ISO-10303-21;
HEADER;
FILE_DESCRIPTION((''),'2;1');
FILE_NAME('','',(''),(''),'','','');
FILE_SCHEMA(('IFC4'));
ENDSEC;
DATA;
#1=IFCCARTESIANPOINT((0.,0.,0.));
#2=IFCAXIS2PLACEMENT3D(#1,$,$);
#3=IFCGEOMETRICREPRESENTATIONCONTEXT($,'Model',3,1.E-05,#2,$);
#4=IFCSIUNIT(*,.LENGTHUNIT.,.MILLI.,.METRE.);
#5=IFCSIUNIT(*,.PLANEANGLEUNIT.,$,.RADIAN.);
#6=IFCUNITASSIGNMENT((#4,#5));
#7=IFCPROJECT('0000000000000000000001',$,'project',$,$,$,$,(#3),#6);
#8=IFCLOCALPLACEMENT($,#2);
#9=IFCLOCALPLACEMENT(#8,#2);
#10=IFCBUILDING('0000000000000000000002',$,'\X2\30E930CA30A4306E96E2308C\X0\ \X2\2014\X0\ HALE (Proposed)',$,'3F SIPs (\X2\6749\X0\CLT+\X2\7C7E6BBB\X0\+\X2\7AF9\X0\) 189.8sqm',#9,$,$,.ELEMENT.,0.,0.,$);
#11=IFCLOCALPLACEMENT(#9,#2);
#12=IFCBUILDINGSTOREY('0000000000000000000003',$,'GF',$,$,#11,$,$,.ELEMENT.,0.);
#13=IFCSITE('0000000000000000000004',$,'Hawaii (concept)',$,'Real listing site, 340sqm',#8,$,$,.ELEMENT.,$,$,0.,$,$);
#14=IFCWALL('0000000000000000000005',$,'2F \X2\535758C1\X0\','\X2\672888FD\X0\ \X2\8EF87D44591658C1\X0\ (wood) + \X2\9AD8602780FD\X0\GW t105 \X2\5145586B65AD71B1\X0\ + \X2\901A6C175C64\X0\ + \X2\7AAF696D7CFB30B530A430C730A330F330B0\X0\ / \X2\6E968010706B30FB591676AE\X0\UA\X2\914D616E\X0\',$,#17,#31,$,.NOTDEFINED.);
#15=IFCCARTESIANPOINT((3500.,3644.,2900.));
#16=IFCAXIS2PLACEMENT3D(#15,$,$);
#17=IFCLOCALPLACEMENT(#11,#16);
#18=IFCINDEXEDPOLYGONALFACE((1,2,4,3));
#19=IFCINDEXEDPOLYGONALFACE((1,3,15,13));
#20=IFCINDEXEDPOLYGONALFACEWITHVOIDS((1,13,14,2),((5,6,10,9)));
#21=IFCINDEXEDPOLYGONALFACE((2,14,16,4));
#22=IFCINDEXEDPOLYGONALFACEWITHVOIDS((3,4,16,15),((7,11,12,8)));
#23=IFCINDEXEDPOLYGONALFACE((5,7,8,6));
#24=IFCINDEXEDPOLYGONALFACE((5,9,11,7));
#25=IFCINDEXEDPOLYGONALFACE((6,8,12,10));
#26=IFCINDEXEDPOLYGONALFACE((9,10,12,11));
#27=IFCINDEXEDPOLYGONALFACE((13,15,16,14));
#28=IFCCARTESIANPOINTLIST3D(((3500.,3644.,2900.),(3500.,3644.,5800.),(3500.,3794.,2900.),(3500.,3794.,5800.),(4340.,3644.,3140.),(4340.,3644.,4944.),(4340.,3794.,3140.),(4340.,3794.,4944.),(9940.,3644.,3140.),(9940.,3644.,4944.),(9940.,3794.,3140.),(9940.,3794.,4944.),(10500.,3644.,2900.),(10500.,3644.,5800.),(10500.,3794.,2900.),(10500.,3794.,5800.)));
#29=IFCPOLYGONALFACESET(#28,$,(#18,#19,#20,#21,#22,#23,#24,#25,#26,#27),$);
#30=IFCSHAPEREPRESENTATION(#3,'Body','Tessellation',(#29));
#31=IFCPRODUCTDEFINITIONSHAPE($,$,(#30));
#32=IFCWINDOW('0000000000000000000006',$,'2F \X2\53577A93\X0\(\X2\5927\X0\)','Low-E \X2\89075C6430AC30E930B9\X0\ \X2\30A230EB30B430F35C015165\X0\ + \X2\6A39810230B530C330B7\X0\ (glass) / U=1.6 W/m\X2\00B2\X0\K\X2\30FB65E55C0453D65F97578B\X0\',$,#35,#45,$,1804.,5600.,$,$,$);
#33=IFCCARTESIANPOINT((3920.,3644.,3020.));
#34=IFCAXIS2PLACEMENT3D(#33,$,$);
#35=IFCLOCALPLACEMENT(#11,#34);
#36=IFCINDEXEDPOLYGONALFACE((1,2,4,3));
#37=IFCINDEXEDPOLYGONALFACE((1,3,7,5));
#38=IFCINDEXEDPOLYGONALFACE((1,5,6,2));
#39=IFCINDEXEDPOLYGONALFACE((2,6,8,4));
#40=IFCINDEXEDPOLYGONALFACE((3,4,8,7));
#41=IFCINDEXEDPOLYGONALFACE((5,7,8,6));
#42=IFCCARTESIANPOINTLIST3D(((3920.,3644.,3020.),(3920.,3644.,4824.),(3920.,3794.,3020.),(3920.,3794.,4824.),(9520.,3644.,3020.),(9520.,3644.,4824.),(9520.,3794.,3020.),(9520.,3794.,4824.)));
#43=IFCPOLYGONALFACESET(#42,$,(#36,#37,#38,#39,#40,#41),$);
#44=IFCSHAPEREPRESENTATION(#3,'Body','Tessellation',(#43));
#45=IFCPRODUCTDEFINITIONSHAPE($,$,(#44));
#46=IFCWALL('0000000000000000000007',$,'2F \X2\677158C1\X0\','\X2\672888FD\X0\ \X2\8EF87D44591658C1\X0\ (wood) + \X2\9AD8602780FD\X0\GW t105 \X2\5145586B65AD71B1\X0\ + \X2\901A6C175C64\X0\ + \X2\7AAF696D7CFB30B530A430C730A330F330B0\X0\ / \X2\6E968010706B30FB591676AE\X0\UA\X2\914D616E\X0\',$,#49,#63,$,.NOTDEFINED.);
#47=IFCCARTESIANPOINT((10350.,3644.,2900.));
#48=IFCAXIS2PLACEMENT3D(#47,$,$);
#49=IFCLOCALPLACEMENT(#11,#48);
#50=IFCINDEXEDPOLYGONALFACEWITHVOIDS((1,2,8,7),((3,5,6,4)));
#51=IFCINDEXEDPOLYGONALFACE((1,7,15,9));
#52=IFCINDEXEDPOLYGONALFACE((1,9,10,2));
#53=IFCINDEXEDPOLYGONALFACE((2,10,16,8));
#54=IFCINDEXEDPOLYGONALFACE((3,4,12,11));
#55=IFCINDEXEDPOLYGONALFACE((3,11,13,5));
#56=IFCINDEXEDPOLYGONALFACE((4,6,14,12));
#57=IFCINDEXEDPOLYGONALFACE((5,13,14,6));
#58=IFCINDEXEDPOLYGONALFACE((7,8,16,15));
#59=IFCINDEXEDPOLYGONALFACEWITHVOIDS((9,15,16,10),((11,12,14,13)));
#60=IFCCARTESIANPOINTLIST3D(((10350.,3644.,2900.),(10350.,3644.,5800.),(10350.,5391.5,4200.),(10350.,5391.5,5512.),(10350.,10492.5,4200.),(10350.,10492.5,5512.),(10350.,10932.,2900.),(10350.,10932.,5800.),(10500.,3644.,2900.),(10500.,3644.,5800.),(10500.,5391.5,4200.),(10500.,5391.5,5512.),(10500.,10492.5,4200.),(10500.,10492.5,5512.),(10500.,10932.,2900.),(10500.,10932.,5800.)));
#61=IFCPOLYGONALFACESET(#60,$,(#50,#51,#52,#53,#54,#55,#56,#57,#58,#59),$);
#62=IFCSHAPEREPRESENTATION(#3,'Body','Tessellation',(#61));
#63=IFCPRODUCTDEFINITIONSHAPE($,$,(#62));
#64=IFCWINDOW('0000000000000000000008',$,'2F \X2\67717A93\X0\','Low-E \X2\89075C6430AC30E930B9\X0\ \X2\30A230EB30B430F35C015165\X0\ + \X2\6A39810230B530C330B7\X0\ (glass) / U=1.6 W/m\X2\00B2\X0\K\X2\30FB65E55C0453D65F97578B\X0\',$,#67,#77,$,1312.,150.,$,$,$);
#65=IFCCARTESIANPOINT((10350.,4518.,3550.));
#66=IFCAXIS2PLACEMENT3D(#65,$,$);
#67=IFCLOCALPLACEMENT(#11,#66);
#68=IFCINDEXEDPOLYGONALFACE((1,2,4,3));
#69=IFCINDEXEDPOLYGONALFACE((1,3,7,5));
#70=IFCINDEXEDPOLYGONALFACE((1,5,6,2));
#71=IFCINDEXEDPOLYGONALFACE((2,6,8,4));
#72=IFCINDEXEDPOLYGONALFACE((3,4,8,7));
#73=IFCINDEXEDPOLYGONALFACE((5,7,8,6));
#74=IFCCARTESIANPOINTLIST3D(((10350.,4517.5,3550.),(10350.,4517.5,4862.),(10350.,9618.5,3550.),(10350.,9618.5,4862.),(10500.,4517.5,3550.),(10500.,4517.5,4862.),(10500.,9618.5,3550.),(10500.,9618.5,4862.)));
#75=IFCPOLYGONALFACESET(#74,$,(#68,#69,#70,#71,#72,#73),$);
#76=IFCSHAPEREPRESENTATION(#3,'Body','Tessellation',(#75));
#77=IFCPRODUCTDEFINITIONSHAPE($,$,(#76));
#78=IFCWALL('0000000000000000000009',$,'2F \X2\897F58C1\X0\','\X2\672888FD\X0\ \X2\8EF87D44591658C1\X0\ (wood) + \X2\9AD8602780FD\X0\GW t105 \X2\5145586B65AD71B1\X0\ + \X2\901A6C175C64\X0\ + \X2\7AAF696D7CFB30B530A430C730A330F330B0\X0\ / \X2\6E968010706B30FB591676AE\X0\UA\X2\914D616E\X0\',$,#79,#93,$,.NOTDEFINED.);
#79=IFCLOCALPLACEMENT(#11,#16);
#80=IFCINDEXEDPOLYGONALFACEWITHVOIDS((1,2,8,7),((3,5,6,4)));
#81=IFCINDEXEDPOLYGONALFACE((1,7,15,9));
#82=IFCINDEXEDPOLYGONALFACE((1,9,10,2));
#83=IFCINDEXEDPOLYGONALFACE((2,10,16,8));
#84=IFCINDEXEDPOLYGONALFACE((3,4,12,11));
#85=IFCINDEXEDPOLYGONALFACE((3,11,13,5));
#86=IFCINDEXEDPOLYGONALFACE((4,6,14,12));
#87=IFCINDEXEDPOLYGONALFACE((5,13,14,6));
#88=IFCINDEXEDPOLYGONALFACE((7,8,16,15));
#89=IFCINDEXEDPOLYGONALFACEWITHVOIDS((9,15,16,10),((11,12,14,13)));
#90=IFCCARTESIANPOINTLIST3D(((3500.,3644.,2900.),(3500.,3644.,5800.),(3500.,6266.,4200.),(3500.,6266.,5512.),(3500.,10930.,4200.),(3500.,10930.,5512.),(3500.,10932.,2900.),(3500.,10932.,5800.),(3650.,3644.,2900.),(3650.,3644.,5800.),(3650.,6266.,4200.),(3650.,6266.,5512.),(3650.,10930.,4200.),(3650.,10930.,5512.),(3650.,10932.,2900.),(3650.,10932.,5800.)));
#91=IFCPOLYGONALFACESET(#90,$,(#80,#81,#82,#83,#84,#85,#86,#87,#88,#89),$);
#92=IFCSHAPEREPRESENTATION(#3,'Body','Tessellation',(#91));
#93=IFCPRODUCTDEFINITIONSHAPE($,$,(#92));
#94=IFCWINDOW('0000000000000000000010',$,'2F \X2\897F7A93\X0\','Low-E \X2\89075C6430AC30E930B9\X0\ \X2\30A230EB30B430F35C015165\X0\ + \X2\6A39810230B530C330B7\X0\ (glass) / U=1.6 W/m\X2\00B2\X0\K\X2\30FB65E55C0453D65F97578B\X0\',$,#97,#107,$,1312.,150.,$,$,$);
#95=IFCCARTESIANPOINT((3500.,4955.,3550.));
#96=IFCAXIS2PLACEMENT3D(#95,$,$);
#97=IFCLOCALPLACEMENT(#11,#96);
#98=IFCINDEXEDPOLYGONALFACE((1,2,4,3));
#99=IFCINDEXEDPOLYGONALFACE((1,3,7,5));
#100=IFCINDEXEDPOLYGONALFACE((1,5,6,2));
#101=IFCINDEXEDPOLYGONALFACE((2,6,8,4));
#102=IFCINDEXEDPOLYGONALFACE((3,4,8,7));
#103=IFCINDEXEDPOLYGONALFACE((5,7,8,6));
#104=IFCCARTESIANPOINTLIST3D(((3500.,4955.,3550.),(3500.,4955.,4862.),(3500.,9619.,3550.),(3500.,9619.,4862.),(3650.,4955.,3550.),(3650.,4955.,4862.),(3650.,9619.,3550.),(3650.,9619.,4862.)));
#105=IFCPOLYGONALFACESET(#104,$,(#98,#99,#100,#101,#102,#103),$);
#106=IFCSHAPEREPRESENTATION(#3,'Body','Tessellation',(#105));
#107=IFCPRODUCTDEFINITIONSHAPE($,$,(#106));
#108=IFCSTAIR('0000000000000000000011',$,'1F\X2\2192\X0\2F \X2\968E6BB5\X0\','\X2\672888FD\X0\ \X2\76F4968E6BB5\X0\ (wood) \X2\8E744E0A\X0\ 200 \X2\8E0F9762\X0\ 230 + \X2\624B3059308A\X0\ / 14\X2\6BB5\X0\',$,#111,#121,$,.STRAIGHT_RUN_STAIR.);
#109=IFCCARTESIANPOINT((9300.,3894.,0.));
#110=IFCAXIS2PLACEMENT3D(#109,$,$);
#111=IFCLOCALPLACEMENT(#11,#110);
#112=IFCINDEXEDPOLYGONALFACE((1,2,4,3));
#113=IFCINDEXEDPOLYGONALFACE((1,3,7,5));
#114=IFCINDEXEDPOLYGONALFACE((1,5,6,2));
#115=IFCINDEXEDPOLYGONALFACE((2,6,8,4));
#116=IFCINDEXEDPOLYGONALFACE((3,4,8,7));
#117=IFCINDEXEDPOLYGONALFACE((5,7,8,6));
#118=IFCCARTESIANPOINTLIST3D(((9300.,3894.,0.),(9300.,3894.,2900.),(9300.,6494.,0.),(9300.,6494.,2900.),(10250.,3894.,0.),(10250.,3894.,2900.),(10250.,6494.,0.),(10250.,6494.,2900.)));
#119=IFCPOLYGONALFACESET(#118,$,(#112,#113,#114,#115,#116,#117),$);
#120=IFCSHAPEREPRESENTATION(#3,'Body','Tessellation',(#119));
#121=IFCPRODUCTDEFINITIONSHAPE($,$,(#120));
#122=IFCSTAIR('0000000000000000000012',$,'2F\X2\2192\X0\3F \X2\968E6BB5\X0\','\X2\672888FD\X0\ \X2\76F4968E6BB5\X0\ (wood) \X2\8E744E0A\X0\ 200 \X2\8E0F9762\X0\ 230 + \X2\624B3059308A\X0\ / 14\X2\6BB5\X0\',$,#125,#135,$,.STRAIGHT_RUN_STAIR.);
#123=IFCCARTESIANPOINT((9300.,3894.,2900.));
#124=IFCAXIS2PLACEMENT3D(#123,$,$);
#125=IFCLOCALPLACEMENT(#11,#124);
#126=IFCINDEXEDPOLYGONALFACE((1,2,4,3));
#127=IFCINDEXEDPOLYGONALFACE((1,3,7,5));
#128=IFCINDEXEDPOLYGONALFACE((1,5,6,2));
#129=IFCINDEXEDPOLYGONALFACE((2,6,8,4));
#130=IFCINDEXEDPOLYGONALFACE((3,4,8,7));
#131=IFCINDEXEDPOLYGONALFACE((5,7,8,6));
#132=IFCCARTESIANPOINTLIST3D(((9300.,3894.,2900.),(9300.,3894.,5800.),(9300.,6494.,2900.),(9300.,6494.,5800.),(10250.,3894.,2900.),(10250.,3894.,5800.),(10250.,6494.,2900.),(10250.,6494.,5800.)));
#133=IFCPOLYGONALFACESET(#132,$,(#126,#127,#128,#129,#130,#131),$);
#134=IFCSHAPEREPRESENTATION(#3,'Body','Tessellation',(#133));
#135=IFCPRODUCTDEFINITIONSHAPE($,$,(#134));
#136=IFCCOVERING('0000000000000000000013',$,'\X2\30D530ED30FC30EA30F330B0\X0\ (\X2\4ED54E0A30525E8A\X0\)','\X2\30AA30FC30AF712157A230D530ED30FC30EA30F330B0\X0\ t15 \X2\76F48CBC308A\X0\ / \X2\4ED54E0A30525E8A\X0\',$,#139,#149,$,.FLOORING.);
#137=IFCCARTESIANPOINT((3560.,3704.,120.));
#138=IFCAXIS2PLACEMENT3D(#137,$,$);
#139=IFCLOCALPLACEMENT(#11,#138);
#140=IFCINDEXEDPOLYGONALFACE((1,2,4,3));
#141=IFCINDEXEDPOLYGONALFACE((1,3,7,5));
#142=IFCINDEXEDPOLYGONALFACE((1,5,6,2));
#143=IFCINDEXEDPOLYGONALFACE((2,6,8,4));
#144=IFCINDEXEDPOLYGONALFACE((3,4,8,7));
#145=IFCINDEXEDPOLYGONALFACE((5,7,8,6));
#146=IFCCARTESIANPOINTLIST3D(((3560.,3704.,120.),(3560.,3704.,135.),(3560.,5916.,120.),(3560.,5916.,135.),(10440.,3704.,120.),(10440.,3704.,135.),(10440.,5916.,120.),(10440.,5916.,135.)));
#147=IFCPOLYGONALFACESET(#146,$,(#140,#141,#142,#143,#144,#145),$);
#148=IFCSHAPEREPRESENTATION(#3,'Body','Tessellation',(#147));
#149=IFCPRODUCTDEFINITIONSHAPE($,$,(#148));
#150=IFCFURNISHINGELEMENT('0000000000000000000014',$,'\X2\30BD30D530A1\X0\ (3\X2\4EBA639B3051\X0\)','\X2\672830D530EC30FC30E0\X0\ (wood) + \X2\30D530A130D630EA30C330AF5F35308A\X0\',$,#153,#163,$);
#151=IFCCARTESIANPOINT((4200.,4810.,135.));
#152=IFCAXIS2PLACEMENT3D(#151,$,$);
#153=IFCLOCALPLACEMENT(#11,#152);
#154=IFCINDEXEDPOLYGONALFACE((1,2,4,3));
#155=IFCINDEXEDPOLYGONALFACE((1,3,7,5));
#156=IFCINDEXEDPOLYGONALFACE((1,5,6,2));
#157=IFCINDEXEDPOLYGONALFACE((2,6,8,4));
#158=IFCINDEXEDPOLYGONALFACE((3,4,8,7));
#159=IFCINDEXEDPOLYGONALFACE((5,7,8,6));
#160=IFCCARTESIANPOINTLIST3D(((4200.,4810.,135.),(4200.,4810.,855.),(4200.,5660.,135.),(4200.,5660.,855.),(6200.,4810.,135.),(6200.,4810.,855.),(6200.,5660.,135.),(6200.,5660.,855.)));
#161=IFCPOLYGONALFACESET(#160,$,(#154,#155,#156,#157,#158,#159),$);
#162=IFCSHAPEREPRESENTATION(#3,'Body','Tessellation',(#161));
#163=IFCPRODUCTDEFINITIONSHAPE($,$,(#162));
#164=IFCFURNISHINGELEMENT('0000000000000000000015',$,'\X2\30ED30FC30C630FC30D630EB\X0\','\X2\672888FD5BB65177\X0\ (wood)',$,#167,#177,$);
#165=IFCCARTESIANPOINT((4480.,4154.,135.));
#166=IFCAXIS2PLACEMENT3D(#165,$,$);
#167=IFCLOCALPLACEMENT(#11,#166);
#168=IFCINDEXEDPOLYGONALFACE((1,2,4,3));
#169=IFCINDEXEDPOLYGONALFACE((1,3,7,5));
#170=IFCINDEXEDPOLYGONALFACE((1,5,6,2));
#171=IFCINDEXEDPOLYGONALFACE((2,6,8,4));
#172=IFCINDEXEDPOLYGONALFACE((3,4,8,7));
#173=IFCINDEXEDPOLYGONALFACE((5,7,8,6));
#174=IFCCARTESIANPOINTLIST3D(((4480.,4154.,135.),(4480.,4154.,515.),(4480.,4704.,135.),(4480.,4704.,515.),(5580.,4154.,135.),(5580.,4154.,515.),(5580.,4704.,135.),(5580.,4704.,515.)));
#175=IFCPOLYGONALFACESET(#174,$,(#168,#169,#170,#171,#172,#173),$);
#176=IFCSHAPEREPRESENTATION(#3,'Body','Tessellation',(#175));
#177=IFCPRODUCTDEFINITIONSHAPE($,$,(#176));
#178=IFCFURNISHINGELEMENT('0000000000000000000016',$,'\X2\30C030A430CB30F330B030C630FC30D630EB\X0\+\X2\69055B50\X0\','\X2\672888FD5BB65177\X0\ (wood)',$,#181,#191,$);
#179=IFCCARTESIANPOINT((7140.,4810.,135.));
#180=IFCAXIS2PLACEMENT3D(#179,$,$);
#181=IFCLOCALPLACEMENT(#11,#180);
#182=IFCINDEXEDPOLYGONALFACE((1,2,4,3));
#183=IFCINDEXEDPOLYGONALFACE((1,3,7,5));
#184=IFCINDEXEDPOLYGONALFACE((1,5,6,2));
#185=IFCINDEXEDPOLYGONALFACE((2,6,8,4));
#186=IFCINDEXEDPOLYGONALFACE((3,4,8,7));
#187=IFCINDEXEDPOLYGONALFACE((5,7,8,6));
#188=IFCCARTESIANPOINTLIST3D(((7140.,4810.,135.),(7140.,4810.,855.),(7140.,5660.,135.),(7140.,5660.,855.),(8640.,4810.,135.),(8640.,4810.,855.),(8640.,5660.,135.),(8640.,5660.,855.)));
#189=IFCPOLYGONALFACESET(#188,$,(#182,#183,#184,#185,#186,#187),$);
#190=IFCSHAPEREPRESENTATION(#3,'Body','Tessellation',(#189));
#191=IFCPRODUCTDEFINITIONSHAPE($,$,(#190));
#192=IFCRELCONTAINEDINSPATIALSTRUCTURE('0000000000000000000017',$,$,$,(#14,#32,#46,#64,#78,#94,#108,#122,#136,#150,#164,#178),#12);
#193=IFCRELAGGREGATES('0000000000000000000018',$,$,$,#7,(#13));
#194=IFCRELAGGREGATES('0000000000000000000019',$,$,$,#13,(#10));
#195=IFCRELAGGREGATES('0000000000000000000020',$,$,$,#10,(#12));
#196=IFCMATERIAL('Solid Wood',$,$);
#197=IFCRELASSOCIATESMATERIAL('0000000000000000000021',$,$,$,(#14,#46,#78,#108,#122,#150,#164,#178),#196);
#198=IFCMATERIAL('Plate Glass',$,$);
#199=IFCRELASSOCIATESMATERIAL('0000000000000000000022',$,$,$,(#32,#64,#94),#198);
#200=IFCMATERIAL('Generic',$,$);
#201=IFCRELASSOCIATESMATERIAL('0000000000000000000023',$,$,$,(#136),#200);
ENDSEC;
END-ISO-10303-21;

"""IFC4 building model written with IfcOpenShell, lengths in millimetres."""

from ifc_helpers import new_model, si_unit, frame, frame_2d, origin, place, context, project, spatial, rectangle, extrude, material, element, fill, save


model = new_model("IFC4")

# Units and contexts
model_context = context("Model", 3, precision=1e-05, world=origin())
ifc_project = project(units=[si_unit("LENGTHUNIT", "METRE", prefix="MILLI"), si_unit("PLANEANGLEUNIT", "RADIAN")], contexts=[model_context])

# Site, building, storey
site_placement = place(None, origin())
site = spatial("IfcSite", under=ifc_project, at=site_placement, Name="Hawaii (concept)", ObjectType="Real listing site, 340sqm", CompositionType="ELEMENT", RefElevation=0.0)
building_placement = place(site_placement, origin())
building = spatial("IfcBuilding", under=site, at=building_placement, Name="ラナイの離れ — HALE (Proposed)", ObjectType="3F SIPs (杉CLT+籾殻+竹) 189.8sqm", CompositionType="ELEMENT", ElevationOfRefHeight=0.0, ElevationOfTerrain=0.0)
storey_placement = place(building_placement, origin())
storey = spatial("IfcBuildingStorey", under=building, at=storey_placement, Name="GF", CompositionType="ELEMENT", Elevation=0.0)

# Shared definitions
ifc_material_1 = material(Name="Solid Wood")

# Shared definitions
ifc_material_2 = material(Name="Plate Glass")

# Walls, openings, windows
wall_1_placement = place(storey_placement, frame((3500.0, 3644.0, 2900.0)))
wall_1 = element("IfcWall", 1, at=wall_1_placement, inside=storey, material=ifc_material_1, Name="2F 南壁", Description="木製 軸組外壁 (wood) + 高性能GW t105 充填断熱 + 通気層 + 窯業系サイディング / 準耐火・外皮UA配慮", PredefinedType="NOTDEFINED", context=model_context, shape_type="SweptSolid", body=[
    extrude(rectangle(XDim=7000.0, YDim=150.0, at=frame_2d((3500.0, 75.0))), frame((3500.0, 3644.0, 2900.0)), (0.0, 0.0, 1.0), 2900.0),
])
opening_1_placement = place(storey_placement, frame((3920.0, 3644.0, 3020.0)))
opening_1 = element("IfcOpeningElement", 2, at=opening_1_placement, cuts=wall_1, PredefinedType="NOTDEFINED", context=model_context, shape_type="SweptSolid", body=[
    extrude(rectangle(XDim=5600.0, YDim=150.0, at=frame_2d((2800.0, 75.0))), frame((3920.0, 3644.0, 3020.0)), (0.0, 0.0, 1.0), 1804.0),
])
window_1_placement = place(storey_placement, frame((3920.0, 3644.0, 3020.0)))
window_1 = element("IfcWindow", 3, at=window_1_placement, inside=storey, material=ifc_material_2, Name="2F 南窓(大)", Description="Low-E 複層ガラス アルゴン封入 + 樹脂サッシ (glass) / U=1.6 W/m²K・日射取得型", OverallHeight=1804.0, OverallWidth=5600.0, context=model_context, shape_type="SweptSolid", body=[
    extrude(rectangle(XDim=5600.0, YDim=150.0, at=frame_2d((2800.0, 75.0))), frame((3920.0, 3644.0, 3020.0)), (0.0, 0.0, 1.0), 1804.0),
])
fill(opening_1, window_1)
wall_2_placement = place(storey_placement, frame((10350.0, 3644.0, 2900.0)))
wall_2 = element("IfcWall", 4, at=wall_2_placement, inside=storey, material=ifc_material_1, Name="2F 東壁", Description="木製 軸組外壁 (wood) + 高性能GW t105 充填断熱 + 通気層 + 窯業系サイディング / 準耐火・外皮UA配慮", PredefinedType="NOTDEFINED", context=model_context, shape_type="SweptSolid", body=[
    extrude(rectangle(XDim=150.0, YDim=7288.0, at=frame_2d((75.0, 3644.0))), frame((10350.0, 3644.0, 2900.0)), (0.0, 0.0, 1.0), 2900.0),
])
opening_2_placement = place(storey_placement, frame((10350.0, 4518.0, 3550.0)))
opening_2 = element("IfcOpeningElement", 5, at=opening_2_placement, cuts=wall_2, PredefinedType="NOTDEFINED", context=model_context, shape_type="SweptSolid", body=[
    extrude(rectangle(XDim=150.0, YDim=5101.0, at=frame_2d((75.0, 2550.0))), frame((10350.0, 4518.0, 3550.0)), (0.0, 0.0, 1.0), 1312.0),
])
window_2_placement = place(storey_placement, frame((10350.0, 4518.0, 3550.0)))
window_2 = element("IfcWindow", 6, at=window_2_placement, inside=storey, material=ifc_material_2, Name="2F 東窓", Description="Low-E 複層ガラス アルゴン封入 + 樹脂サッシ (glass) / U=1.6 W/m²K・日射取得型", OverallHeight=1312.0, OverallWidth=150.0, context=model_context, shape_type="SweptSolid", body=[
    extrude(rectangle(XDim=150.0, YDim=5101.0, at=frame_2d((75.0, 2550.0))), frame((10350.0, 4518.0, 3550.0)), (0.0, 0.0, 1.0), 1312.0),
])
fill(opening_2, window_2)
wall_3_placement = place(storey_placement, frame((3500.0, 3644.0, 2900.0)))
wall_3 = element("IfcWall", 7, at=wall_3_placement, inside=storey, material=ifc_material_1, Name="2F 西壁", Description="木製 軸組外壁 (wood) + 高性能GW t105 充填断熱 + 通気層 + 窯業系サイディング / 準耐火・外皮UA配慮", PredefinedType="NOTDEFINED", context=model_context, shape_type="SweptSolid", body=[
    extrude(rectangle(XDim=150.0, YDim=7288.0, at=frame_2d((75.0, 3644.0))), frame((3500.0, 3644.0, 2900.0)), (0.0, 0.0, 1.0), 2900.0),
])
opening_3_placement = place(storey_placement, frame((3500.0, 4955.0, 3550.0)))
opening_3 = element("IfcOpeningElement", 8, at=opening_3_placement, cuts=wall_3, PredefinedType="NOTDEFINED", context=model_context, shape_type="SweptSolid", body=[
    extrude(rectangle(XDim=150.0, YDim=4664.0, at=frame_2d((75.0, 2332.0))), frame((3500.0, 4955.0, 3550.0)), (0.0, 0.0, 1.0), 1312.0),
])
window_3_placement = place(storey_placement, frame((3500.0, 4955.0, 3550.0)))
window_3 = element("IfcWindow", 9, at=window_3_placement, inside=storey, material=ifc_material_2, Name="2F 西窓", Description="Low-E 複層ガラス アルゴン封入 + 樹脂サッシ (glass) / U=1.6 W/m²K・日射取得型", OverallHeight=1312.0, OverallWidth=150.0, context=model_context, shape_type="SweptSolid", body=[
    extrude(rectangle(XDim=150.0, YDim=4664.0, at=frame_2d((75.0, 2332.0))), frame((3500.0, 4955.0, 3550.0)), (0.0, 0.0, 1.0), 1312.0),
])
fill(opening_3, window_3)

# Stairs
stair_1_placement = place(storey_placement, frame((9300.0, 3894.0, 0.0)))
element("IfcStair", 10, at=stair_1_placement, inside=storey, material=ifc_material_1, Name="1F→2F 階段", Description="木製 直階段 (wood) 蹴上 200 踏面 230 + 手すり / 14段", PredefinedType="STRAIGHT_RUN_STAIR", context=model_context, shape_type="SweptSolid", body=[
    extrude(rectangle(XDim=950.0, YDim=2600.0, at=frame_2d((475.0, 1300.0))), frame((9300.0, 3894.0, 0.0)), (0.0, 0.0, 1.0), 2900.0),
])
stair_2_placement = place(storey_placement, frame((9300.0, 3894.0, 2900.0)))
element("IfcStair", 11, at=stair_2_placement, inside=storey, material=ifc_material_1, Name="2F→3F 階段", Description="木製 直階段 (wood) 蹴上 200 踏面 230 + 手すり / 14段", PredefinedType="STRAIGHT_RUN_STAIR", context=model_context, shape_type="SweptSolid", body=[
    extrude(rectangle(XDim=950.0, YDim=2600.0, at=frame_2d((475.0, 1300.0))), frame((9300.0, 3894.0, 2900.0)), (0.0, 0.0, 1.0), 2900.0),
])

# Covering
ifc_material_3 = material(Name="Generic")
covering_placement = place(storey_placement, frame((3560.0, 3704.0, 120.0)))
element("IfcCovering", 12, at=covering_placement, inside=storey, material=ifc_material_3, Name="フローリング (仕上げ床)", Description="オーク無垢フローリング t15 直貼り / 仕上げ床", PredefinedType="FLOORING", context=model_context, shape_type="SweptSolid", body=[
    extrude(rectangle(XDim=6880.0, YDim=2212.0, at=frame_2d((3440.0, 1106.0))), frame((3560.0, 3704.0, 120.0)), (0.0, 0.0, 1.0), 15.0),
])

# Furnishing elements
furnishing_1_placement = place(storey_placement, frame((4200.0, 4810.0, 135.0)))
element("IfcFurnishingElement", 13, at=furnishing_1_placement, inside=storey, material=ifc_material_1, Name="ソファ (3人掛け)", Description="木フレーム (wood) + ファブリック張り", context=model_context, shape_type="SweptSolid", body=[
    extrude(rectangle(XDim=2000.0, YDim=850.0, at=frame_2d((1000.0, 425.0))), frame((4200.0, 4810.0, 135.0)), (0.0, 0.0, 1.0), 720.0),
])
furnishing_2_placement = place(storey_placement, frame((4480.0, 4154.0, 135.0)))
element("IfcFurnishingElement", 14, at=furnishing_2_placement, inside=storey, material=ifc_material_1, Name="ローテーブル", Description="木製家具 (wood)", context=model_context, shape_type="SweptSolid", body=[
    extrude(rectangle(XDim=1100.0, YDim=550.0, at=frame_2d((550.0, 275.0))), frame((4480.0, 4154.0, 135.0)), (0.0, 0.0, 1.0), 380.0),
])
furnishing_3_placement = place(storey_placement, frame((7140.0, 4810.0, 135.0)))
element("IfcFurnishingElement", 15, at=furnishing_3_placement, inside=storey, material=ifc_material_1, Name="ダイニングテーブル+椅子", Description="木製家具 (wood)", context=model_context, shape_type="SweptSolid", body=[
    extrude(rectangle(XDim=1500.0, YDim=850.0, at=frame_2d((750.0, 425.0))), frame((7140.0, 4810.0, 135.0)), (0.0, 0.0, 1.0), 720.0),
])

save(model, "model.ifc")
